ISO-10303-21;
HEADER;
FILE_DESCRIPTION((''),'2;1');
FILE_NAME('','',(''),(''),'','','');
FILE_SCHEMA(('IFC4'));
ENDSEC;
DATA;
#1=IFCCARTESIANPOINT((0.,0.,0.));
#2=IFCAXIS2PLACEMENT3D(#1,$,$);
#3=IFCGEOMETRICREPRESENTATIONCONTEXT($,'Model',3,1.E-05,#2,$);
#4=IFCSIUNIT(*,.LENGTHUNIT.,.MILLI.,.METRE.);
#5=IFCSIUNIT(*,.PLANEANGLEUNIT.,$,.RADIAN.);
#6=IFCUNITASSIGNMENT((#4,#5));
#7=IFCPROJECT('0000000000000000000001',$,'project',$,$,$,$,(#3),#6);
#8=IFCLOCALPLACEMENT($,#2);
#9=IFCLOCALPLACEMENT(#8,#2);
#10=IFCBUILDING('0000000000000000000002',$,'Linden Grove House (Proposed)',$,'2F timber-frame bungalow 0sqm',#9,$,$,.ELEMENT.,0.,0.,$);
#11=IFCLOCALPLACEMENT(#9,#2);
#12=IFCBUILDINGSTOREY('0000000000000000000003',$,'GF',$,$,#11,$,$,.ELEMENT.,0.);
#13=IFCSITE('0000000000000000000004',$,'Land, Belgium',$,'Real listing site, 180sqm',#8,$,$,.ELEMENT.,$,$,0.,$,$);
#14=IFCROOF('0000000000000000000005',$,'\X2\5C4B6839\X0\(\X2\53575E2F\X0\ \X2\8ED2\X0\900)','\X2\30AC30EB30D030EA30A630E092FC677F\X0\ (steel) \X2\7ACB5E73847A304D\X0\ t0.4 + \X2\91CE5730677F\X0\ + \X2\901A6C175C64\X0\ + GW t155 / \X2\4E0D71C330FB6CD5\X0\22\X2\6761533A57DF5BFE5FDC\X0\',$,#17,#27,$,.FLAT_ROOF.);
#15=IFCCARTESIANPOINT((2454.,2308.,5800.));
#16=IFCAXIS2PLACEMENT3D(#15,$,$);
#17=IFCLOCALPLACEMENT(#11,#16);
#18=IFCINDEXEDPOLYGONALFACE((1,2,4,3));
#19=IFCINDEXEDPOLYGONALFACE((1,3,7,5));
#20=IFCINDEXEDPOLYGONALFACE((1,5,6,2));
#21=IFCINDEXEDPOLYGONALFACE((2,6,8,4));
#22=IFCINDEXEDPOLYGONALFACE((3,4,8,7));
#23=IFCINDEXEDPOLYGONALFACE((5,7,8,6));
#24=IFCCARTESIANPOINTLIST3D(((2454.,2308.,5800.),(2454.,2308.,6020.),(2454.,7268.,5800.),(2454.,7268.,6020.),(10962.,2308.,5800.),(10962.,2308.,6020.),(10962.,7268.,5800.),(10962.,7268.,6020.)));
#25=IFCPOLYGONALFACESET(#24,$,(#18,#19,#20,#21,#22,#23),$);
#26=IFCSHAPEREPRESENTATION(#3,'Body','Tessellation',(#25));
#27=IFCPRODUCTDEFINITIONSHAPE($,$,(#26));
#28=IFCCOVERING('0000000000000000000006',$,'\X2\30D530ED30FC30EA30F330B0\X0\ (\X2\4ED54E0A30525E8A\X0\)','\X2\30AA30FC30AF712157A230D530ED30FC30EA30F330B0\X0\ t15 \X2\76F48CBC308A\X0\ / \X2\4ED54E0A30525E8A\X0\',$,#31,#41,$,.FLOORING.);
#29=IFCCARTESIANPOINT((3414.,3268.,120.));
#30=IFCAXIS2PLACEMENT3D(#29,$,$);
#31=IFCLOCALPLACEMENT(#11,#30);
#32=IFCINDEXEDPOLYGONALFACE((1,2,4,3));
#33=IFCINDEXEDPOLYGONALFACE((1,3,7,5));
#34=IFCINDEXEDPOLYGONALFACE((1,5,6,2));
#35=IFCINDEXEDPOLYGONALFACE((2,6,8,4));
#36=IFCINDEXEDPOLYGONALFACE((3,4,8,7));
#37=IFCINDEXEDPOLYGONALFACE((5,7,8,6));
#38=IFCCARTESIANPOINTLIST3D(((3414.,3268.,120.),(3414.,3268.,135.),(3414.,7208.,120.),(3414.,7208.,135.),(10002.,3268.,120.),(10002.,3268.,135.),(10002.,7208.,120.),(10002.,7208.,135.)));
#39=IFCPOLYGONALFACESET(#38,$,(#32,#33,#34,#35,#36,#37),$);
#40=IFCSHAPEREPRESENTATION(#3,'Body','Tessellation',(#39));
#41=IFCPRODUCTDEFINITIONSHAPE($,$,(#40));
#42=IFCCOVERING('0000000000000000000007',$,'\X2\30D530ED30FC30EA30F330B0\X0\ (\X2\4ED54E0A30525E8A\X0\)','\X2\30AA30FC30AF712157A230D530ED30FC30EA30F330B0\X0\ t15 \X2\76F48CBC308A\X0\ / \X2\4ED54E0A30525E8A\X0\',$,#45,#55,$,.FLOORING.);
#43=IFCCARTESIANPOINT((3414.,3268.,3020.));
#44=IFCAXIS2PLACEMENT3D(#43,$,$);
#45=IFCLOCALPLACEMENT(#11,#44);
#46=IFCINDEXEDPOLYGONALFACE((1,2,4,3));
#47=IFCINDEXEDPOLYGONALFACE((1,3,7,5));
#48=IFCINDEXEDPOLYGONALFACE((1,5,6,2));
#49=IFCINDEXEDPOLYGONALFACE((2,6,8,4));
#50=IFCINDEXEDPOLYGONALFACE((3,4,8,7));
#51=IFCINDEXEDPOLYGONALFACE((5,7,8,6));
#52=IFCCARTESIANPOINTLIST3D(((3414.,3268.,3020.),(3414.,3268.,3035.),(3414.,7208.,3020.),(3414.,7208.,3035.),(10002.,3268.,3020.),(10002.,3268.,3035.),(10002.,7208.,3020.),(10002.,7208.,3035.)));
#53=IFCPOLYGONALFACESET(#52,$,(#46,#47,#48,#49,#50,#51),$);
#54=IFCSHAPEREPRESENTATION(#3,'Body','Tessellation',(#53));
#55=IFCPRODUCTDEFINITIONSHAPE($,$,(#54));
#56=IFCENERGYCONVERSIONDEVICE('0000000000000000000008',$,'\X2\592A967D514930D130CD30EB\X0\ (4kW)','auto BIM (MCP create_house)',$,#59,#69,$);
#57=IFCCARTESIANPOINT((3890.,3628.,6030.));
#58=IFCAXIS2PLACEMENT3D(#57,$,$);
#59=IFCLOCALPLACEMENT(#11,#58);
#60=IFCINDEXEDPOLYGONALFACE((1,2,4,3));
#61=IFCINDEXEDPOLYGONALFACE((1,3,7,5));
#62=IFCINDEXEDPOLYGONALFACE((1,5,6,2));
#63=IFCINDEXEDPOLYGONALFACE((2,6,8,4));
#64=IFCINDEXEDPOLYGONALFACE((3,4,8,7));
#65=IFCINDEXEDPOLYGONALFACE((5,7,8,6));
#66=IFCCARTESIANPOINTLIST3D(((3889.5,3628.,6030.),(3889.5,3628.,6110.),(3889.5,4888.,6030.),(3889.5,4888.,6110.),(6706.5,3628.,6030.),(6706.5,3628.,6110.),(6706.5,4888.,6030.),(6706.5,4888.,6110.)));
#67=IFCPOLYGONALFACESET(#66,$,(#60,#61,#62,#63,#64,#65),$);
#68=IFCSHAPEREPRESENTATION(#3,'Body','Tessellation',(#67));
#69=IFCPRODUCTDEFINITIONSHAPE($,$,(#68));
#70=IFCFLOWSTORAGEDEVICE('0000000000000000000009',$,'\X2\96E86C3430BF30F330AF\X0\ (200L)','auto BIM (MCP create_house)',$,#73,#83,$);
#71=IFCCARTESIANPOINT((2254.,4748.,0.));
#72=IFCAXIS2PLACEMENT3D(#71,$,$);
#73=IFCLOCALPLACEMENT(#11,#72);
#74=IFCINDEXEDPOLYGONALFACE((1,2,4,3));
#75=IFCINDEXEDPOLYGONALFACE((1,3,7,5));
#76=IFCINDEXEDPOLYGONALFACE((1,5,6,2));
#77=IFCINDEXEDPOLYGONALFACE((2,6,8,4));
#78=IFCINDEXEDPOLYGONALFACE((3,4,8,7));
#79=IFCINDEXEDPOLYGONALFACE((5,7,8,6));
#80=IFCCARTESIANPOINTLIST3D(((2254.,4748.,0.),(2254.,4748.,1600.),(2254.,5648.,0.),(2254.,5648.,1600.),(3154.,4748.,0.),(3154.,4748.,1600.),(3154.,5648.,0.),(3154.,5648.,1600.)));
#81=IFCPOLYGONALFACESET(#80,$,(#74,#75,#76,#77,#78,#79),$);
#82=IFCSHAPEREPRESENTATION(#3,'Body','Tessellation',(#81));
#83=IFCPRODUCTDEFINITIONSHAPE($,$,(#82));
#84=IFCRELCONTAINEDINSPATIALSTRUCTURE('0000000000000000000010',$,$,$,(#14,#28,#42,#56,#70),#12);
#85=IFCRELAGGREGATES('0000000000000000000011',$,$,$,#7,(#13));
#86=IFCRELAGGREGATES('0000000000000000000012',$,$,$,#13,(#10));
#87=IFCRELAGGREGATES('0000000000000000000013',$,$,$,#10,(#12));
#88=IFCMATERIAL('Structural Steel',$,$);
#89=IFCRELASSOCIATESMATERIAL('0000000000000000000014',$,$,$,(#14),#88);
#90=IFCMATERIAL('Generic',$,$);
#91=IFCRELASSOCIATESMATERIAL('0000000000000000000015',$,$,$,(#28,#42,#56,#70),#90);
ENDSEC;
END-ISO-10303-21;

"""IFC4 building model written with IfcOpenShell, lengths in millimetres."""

from ifc_helpers import new_model, si_unit, frame, frame_2d, origin, place, context, project, spatial, rectangle, extrude, material, element, save


model = new_model("IFC4")

# Units and contexts
model_context = context("Model", 3, precision=1e-05, world=origin())
ifc_project = project(units=[si_unit("LENGTHUNIT", "METRE", prefix="MILLI"), si_unit("PLANEANGLEUNIT", "RADIAN")], contexts=[model_context])

# Site, building, storey
site_placement = place(None, origin())
site = spatial("IfcSite", under=ifc_project, at=site_placement, Name="Land, Belgium", ObjectType="Real listing site, 180sqm", CompositionType="ELEMENT", RefElevation=0.0)
building_placement = place(site_placement, origin())
building = spatial("IfcBuilding", under=site, at=building_placement, Name="Linden Grove House (Proposed)", ObjectType="2F timber-frame bungalow 0sqm", CompositionType="ELEMENT", ElevationOfRefHeight=0.0, ElevationOfTerrain=0.0)
storey_placement = place(building_placement, origin())
storey = spatial("IfcBuildingStorey", under=building, at=storey_placement, Name="GF", CompositionType="ELEMENT", Elevation=0.0)

# Roof
ifc_material_1 = material(Name="Structural Steel")
for number, where, name in (
    (1, (2454.0, 2308.0, 5800.0), "屋根(南帯 軒900)"),
):
    element("IfcRoof", number, at=place(storey_placement, frame(where)), inside=storey, material=ifc_material_1, Name=name, Description="ガルバリウム鋼板 (steel) 立平葺き t0.4 + 野地板 + 通気層 + GW t155 / 不燃・法22条区域対応", PredefinedType="FLAT_ROOF", context=model_context, shape_type="SweptSolid", body=[
        extrude(rectangle(XDim=8508.0, YDim=4960.0, at=frame_2d((4254.0, 2480.0))), frame((2454.0, 2308.0, 5800.0)), (0.0, 0.0, 1.0), 220.0),
    ])

# Coverings
ifc_material_2 = material(Name="Generic")
covering_1_placement = place(storey_placement, frame((3414.0, 3268.0, 120.0)))
element("IfcCovering", 2, at=covering_1_placement, inside=storey, material=ifc_material_2, Name="フローリング (仕上げ床)", Description="オーク無垢フローリング t15 直貼り / 仕上げ床", PredefinedType="FLOORING", context=model_context, shape_type="SweptSolid", body=[
    extrude(rectangle(XDim=6588.0, YDim=3940.0, at=frame_2d((3294.0, 1970.0))), frame((3414.0, 3268.0, 120.0)), (0.0, 0.0, 1.0), 15.0),
])
covering_2_placement = place(storey_placement, frame((3414.0, 3268.0, 3020.0)))
element("IfcCovering", 3, at=covering_2_placement, inside=storey, material=ifc_material_2, Name="フローリング (仕上げ床)", Description="オーク無垢フローリング t15 直貼り / 仕上げ床", PredefinedType="FLOORING", context=model_context, shape_type="SweptSolid", body=[
    extrude(rectangle(XDim=6588.0, YDim=3940.0, at=frame_2d((3294.0, 1970.0))), frame((3414.0, 3268.0, 3020.0)), (0.0, 0.0, 1.0), 15.0),
])

# Energy conversion device
energy_conversion_device_placement = place(storey_placement, frame((3890.0, 3628.0, 6030.0)))
element("IfcEnergyConversionDevice", 4, at=energy_conversion_device_placement, inside=storey, material=ifc_material_2, Name="太陽光パネル (4kW)", Description="auto BIM (MCP create_house)", context=model_context, shape_type="SweptSolid", body=[
    extrude(rectangle(XDim=2817.0, YDim=1260.0, at=frame_2d((1408.0, 630.0))), frame((3890.0, 3628.0, 6030.0)), (0.0, 0.0, 1.0), 80.0),
])

# Flow storage device
flow_storage_device_placement = place(storey_placement, frame((2254.0, 4748.0, 0.0)))
element("IfcFlowStorageDevice", 5, at=flow_storage_device_placement, inside=storey, material=ifc_material_2, Name="雨水タンク (200L)", Description="auto BIM (MCP create_house)", context=model_context, shape_type="SweptSolid", body=[
    extrude(rectangle(XDim=900.0, YDim=900.0, at=frame_2d((450.0, 450.0))), frame((2254.0, 4748.0, 0.0)), (0.0, 0.0, 1.0), 1600.0),
])

save(model, "model.ifc")
